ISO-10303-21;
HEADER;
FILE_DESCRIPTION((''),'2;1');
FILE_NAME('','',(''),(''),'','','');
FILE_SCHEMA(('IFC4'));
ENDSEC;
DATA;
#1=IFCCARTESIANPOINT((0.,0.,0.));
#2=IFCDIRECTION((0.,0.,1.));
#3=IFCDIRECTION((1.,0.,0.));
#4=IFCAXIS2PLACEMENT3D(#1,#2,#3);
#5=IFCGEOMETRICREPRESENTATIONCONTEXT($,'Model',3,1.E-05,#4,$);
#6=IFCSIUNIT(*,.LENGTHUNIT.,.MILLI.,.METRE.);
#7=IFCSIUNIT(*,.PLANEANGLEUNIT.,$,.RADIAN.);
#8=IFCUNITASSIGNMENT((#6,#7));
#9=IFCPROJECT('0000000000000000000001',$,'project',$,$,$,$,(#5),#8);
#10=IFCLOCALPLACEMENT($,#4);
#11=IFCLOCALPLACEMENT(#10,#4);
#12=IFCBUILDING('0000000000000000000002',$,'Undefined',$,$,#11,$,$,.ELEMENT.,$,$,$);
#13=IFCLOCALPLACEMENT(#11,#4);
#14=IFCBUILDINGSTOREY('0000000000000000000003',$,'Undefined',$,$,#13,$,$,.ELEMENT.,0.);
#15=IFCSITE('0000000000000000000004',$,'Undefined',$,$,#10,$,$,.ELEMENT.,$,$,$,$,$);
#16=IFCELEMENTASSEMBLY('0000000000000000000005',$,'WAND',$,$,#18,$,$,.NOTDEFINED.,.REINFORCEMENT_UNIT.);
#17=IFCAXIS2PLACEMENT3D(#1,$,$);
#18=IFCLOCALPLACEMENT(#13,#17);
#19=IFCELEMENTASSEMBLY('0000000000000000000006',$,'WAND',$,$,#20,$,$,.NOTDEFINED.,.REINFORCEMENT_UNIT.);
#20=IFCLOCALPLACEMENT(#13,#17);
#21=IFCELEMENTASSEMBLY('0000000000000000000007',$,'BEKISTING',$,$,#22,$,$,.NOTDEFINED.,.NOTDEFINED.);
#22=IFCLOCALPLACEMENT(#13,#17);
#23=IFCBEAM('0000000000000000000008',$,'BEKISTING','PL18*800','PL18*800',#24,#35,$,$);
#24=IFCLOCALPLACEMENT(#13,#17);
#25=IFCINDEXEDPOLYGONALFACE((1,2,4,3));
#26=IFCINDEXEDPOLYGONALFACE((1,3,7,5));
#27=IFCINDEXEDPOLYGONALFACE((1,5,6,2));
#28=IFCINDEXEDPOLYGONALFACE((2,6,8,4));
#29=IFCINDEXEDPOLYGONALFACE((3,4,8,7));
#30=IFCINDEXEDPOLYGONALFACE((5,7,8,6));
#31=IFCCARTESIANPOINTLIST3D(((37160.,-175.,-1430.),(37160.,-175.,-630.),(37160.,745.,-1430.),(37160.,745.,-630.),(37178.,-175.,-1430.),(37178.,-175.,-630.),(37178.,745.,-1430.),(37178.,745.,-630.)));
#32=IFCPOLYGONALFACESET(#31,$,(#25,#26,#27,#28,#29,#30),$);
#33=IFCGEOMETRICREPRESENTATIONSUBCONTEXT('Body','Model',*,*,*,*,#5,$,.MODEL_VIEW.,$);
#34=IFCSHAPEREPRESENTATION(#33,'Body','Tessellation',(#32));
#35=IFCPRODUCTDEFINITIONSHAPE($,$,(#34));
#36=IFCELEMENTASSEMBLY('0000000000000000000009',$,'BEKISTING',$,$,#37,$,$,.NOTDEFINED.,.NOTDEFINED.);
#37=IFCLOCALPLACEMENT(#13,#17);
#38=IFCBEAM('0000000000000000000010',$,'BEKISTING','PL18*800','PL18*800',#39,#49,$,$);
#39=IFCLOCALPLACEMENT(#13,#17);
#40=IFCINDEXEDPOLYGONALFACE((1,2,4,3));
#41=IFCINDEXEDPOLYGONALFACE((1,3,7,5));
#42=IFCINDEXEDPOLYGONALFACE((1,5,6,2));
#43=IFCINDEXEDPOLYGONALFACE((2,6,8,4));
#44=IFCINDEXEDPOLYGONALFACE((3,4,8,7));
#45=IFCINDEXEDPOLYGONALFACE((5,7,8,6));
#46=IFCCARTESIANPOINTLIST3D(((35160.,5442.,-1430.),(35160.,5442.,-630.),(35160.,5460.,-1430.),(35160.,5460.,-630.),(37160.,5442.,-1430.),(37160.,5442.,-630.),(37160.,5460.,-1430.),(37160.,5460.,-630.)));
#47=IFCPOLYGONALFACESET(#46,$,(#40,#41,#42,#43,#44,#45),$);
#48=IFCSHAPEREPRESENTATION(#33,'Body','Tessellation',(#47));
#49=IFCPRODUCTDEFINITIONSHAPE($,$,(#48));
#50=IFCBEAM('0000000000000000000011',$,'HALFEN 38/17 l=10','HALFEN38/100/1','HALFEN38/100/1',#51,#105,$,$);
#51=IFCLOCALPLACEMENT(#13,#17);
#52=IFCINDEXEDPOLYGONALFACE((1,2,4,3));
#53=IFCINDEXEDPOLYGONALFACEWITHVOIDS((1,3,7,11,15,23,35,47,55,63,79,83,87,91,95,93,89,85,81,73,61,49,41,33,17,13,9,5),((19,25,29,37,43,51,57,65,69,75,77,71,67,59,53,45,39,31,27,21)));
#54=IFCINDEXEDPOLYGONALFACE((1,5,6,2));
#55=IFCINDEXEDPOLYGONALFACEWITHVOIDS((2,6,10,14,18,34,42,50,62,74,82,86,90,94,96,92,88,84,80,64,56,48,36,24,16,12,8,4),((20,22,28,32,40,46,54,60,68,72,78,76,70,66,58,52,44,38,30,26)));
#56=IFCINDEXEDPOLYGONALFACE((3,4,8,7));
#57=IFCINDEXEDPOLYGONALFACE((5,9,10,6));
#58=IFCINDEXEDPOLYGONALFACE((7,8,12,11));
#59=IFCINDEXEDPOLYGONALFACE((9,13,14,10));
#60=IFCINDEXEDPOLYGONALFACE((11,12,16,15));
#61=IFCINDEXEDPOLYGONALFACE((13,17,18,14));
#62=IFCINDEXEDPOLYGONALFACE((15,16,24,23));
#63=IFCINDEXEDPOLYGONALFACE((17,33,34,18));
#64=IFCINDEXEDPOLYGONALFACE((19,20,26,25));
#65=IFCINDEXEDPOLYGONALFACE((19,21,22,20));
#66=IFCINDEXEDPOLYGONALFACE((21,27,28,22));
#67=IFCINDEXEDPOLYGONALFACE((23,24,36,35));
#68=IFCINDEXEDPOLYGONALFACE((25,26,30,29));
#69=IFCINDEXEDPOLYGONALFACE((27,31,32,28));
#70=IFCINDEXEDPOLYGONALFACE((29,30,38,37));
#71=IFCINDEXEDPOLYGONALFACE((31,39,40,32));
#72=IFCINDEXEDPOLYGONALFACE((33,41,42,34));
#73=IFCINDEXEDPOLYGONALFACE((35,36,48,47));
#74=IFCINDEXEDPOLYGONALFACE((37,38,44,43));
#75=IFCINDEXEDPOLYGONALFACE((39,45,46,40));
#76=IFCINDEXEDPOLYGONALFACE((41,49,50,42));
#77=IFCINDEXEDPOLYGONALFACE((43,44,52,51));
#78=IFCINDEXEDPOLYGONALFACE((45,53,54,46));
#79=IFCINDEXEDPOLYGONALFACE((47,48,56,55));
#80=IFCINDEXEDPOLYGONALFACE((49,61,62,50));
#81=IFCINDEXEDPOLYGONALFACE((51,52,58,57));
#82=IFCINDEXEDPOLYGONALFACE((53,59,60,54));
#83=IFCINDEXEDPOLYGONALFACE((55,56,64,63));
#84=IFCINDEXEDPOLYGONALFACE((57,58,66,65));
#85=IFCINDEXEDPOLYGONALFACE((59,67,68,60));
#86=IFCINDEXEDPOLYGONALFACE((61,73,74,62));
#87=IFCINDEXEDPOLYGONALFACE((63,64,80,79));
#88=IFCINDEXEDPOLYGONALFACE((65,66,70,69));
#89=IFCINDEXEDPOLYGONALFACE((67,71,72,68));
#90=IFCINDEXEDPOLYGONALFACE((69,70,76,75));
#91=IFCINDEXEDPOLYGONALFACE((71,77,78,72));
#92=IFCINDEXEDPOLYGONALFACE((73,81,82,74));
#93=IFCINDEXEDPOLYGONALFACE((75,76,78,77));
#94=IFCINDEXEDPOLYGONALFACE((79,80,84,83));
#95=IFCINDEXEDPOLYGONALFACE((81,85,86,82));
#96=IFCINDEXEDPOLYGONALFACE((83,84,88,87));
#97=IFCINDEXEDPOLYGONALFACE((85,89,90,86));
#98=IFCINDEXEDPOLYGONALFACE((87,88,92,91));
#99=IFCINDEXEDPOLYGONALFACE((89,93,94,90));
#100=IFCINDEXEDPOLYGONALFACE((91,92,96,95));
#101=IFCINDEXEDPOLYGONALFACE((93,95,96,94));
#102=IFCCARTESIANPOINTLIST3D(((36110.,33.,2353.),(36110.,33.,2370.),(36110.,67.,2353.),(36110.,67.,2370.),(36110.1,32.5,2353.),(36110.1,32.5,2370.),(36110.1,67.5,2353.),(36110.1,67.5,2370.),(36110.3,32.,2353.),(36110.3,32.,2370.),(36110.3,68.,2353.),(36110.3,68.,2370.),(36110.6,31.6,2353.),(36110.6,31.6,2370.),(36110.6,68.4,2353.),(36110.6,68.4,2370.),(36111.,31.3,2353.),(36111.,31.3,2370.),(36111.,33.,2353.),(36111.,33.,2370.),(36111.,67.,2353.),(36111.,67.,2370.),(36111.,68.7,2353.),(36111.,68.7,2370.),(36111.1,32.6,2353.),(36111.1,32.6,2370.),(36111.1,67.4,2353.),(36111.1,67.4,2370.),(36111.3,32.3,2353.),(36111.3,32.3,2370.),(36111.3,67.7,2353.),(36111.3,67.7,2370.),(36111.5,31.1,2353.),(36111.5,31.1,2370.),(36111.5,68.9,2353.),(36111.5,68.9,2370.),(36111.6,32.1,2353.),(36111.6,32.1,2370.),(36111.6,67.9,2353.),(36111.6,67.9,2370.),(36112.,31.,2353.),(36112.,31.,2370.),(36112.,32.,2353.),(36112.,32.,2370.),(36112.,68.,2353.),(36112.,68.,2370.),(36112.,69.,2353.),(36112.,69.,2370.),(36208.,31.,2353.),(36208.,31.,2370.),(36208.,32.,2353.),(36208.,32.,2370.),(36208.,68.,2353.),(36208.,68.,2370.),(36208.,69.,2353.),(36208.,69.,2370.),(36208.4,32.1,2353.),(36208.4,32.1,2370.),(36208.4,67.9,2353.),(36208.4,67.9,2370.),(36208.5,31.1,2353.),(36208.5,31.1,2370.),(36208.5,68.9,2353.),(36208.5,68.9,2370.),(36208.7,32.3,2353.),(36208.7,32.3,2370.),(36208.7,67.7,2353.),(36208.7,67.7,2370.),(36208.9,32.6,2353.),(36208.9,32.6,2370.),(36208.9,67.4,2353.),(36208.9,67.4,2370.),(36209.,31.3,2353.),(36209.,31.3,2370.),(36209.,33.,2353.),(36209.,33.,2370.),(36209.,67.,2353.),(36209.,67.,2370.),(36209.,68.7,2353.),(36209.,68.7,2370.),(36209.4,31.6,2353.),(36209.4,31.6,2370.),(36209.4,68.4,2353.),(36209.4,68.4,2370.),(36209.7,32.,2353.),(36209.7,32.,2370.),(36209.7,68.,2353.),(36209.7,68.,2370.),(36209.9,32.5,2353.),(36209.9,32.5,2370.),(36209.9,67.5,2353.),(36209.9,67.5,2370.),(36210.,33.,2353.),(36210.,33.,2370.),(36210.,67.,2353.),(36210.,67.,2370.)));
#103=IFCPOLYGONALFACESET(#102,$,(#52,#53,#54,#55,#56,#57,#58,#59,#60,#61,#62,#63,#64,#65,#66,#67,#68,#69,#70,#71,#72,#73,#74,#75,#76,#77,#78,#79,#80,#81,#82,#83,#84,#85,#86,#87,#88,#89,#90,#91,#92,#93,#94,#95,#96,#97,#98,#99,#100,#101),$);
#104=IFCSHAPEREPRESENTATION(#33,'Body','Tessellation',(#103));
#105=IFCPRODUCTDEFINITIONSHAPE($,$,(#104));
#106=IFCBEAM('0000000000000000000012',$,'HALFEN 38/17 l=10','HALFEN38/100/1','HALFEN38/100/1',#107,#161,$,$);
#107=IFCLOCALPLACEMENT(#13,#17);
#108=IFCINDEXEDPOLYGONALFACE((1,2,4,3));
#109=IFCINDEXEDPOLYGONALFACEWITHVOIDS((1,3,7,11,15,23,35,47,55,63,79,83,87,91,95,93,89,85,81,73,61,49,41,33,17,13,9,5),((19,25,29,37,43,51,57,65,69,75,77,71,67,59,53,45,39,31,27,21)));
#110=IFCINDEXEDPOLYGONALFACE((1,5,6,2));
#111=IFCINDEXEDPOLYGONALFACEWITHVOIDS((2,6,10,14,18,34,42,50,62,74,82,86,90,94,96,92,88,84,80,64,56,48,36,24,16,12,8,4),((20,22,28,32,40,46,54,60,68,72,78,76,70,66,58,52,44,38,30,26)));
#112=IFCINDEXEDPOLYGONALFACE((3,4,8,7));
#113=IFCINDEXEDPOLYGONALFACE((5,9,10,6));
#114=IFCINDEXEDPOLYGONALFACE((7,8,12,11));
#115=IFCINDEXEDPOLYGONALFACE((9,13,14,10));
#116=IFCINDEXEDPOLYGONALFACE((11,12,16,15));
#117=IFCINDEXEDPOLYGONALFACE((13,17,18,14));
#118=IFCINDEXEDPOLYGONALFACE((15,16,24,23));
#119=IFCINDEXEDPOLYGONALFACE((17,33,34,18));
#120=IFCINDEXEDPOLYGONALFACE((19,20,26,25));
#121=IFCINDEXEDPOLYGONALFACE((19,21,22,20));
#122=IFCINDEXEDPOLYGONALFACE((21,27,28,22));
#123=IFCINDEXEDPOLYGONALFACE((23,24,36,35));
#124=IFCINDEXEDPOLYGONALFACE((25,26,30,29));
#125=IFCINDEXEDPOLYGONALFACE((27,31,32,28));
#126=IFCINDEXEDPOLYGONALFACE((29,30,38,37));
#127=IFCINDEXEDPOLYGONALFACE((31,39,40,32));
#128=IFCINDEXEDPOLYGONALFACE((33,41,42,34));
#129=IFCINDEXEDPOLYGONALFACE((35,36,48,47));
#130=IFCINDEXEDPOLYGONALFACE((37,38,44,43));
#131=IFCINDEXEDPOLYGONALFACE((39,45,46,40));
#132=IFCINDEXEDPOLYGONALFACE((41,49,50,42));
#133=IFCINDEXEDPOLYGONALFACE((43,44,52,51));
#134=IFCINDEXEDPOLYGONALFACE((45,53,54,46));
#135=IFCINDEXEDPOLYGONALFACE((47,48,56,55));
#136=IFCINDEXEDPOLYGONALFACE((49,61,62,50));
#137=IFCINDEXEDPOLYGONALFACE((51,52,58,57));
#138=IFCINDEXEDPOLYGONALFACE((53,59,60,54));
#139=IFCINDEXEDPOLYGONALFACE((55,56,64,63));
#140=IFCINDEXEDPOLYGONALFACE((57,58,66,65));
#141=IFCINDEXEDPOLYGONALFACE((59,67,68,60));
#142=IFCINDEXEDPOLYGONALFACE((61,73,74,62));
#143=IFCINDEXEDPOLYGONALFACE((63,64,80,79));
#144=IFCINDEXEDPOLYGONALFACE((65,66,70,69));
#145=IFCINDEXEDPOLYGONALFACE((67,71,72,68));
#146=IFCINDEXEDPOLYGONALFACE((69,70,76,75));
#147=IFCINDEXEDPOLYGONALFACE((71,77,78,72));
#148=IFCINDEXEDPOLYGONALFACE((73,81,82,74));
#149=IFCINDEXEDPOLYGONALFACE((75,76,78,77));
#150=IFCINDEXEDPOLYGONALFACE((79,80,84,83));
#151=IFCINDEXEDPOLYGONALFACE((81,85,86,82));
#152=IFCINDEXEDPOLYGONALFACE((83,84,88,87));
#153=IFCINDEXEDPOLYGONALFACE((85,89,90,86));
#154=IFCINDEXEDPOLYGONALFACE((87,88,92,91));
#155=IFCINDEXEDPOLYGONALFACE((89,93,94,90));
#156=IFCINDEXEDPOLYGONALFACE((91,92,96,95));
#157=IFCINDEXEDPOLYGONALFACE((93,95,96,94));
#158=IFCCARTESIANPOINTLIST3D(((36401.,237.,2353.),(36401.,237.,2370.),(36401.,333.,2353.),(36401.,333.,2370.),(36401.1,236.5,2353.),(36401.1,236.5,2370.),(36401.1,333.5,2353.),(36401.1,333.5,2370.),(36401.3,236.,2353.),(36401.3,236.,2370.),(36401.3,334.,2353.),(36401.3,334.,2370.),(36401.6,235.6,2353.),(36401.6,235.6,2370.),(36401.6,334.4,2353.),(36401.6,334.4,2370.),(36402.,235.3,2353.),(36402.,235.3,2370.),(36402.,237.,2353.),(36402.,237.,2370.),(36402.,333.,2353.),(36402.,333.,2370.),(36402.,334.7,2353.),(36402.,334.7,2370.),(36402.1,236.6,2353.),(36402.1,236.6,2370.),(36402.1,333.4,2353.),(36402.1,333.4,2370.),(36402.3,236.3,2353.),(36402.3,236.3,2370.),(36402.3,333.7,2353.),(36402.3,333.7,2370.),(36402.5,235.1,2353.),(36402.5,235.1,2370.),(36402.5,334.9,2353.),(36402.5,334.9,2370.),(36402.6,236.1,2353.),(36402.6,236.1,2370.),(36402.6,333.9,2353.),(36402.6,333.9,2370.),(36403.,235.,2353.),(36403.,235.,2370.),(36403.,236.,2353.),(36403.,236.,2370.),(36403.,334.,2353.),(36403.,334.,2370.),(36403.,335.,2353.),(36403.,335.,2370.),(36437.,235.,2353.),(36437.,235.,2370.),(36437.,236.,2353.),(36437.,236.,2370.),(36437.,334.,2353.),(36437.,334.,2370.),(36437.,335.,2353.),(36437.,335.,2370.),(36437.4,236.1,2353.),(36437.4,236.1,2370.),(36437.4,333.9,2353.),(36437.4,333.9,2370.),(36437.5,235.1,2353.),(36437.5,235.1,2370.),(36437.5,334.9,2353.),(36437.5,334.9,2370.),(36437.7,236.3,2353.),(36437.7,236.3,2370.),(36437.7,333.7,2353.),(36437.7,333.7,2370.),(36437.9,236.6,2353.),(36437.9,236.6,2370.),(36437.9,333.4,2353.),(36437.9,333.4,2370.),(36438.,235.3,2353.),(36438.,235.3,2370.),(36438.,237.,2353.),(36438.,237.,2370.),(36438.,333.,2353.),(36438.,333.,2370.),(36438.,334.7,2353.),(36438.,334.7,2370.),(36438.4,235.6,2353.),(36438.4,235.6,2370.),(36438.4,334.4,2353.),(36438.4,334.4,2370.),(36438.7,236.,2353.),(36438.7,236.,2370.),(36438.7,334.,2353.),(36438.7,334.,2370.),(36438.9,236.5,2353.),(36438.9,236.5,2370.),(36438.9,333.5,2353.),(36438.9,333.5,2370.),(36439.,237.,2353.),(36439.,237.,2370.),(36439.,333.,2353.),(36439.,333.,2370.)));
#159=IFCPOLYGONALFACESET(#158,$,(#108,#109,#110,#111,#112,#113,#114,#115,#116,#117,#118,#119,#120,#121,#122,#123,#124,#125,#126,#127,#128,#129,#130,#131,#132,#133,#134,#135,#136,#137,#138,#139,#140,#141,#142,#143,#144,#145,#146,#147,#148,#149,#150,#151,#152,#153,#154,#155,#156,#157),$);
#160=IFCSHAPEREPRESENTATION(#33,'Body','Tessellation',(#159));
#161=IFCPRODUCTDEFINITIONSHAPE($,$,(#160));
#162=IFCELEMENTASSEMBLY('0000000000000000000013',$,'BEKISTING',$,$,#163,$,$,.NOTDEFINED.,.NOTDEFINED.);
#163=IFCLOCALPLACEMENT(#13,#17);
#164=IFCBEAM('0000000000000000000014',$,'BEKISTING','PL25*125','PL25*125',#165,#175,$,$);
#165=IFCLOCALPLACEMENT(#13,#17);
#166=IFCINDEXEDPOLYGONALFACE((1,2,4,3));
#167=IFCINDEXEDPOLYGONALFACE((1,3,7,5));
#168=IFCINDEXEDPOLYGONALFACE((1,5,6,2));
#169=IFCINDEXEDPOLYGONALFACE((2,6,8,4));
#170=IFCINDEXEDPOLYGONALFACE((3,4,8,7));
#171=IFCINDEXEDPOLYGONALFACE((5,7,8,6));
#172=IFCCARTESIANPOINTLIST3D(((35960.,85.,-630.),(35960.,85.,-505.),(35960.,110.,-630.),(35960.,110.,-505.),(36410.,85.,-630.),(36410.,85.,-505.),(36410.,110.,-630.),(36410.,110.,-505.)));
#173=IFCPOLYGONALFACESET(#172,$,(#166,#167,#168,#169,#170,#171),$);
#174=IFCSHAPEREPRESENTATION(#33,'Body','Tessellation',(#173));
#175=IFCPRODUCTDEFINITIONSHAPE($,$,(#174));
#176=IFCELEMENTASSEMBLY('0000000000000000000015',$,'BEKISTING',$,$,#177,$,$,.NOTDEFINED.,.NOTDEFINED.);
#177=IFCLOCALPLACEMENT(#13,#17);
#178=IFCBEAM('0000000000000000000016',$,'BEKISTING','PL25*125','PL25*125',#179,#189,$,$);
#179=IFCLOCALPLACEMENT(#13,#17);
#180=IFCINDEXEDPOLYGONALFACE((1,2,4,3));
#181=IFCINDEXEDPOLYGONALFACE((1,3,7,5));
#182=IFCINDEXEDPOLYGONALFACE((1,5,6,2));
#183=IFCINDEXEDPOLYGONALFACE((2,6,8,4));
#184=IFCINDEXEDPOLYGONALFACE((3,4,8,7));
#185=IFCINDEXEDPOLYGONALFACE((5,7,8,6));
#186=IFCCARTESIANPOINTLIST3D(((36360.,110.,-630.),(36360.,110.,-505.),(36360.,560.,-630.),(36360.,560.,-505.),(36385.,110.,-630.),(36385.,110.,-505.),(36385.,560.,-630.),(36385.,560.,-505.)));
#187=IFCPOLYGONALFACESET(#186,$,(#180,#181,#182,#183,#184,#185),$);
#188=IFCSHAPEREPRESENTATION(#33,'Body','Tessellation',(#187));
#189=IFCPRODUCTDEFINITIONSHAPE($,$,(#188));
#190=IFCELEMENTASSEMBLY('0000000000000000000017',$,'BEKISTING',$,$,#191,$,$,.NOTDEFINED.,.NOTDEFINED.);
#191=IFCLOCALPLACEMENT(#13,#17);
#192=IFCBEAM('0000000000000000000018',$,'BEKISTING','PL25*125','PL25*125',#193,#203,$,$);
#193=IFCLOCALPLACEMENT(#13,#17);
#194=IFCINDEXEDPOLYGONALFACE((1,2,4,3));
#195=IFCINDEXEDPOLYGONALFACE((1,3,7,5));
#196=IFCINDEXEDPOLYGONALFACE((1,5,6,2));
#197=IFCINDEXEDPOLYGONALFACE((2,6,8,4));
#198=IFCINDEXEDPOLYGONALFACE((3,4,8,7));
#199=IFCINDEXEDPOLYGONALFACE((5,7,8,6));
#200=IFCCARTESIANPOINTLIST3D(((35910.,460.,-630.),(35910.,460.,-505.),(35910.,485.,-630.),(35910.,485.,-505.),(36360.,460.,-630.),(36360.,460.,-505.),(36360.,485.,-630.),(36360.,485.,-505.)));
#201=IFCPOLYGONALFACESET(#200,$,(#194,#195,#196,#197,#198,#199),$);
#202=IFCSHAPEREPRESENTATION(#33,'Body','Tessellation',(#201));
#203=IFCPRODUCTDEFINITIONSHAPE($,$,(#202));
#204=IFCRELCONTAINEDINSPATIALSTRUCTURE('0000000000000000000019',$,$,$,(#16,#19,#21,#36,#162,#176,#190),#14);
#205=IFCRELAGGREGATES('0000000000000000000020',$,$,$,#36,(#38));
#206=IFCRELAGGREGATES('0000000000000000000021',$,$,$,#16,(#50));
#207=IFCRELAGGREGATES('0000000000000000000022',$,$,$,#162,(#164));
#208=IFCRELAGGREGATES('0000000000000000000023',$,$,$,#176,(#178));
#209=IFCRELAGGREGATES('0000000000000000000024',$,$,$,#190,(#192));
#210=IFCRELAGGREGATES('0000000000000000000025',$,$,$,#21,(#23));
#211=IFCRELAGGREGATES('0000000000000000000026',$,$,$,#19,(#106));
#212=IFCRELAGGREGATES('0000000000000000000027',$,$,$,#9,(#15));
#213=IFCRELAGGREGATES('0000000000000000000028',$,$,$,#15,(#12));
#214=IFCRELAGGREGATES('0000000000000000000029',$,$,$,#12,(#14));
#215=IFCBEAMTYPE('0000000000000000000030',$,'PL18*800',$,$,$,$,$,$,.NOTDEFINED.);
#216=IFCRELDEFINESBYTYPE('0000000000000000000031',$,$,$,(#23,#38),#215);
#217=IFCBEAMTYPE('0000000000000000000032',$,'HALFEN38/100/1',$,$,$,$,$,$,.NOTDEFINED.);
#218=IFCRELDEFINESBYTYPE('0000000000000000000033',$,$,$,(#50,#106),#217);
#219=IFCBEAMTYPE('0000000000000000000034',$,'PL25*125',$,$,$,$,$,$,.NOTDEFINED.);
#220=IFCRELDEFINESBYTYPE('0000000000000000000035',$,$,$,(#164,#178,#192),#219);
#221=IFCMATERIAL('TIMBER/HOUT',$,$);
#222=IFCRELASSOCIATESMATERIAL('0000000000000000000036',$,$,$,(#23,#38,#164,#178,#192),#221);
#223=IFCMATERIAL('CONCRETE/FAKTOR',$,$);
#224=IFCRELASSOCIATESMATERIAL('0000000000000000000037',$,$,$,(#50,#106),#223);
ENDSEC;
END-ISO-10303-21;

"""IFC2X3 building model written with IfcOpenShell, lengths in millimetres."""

from ifc_helpers import new_model, si_unit, frame, frame_2d, origin_with_axes, place, context, subcontext, project, spatial, rectangle, hollow_rectangle, extrude, material, type_object, element, aggregate, save


model = new_model("IFC2X3")

# Units and contexts
model_context = context("Model", 3, precision=1e-05, world=origin_with_axes())
body_context = subcontext(model_context, "Body", "Model", "MODEL_VIEW")
ifc_project = project(units=[si_unit("LENGTHUNIT", "METRE", prefix="MILLI"), si_unit("PLANEANGLEUNIT", "RADIAN")], contexts=[model_context])

# Site, building, storey
site_placement = place(None, origin_with_axes())
site = spatial("IfcSite", under=ifc_project, at=site_placement, Name="Undefined", CompositionType="ELEMENT")
building_placement = place(site_placement, origin_with_axes())
building = spatial("IfcBuilding", under=site, at=building_placement, Name="Undefined", CompositionType="ELEMENT")
storey_placement = place(building_placement, origin_with_axes())
storey = spatial("IfcBuildingStorey", under=building, at=storey_placement, Name="Undefined", CompositionType="ELEMENT", Elevation=0.0)

# Element assemblies
assembly_1_placement = place(storey_placement, origin_with_axes())
assembly_1 = element("IfcElementAssembly", 1, at=assembly_1_placement, inside=storey, Name="WAND", AssemblyPlace="NOTDEFINED", PredefinedType="REINFORCEMENT_UNIT")
ifc_material_1 = material(Name="CONCRETE/FAKTOR")
assembly_2_placement = place(storey_placement, origin_with_axes())
assembly_2 = element("IfcElementAssembly", 2, at=assembly_2_placement, inside=storey, Name="WAND", AssemblyPlace="NOTDEFINED", PredefinedType="REINFORCEMENT_UNIT")

# Element assemblies, beams
ifc_material_2 = material(Name="TIMBER/HOUT")
beam_type_1 = type_object("IfcBeamType", Name="PL18*800", PredefinedType="NOTDEFINED")
assembly_3_placement = place(storey_placement, origin_with_axes())
assembly_3 = element("IfcElementAssembly", 3, at=assembly_3_placement, inside=storey, Name="BEKISTING", AssemblyPlace="NOTDEFINED", PredefinedType="NOTDEFINED")
beam_1_placement = place(assembly_3_placement, frame((37169.0, 745.0, -1030.0), z_axis=(0.0, 0.0, 1.0), x_axis=(0.0, -1.0, 0.0)))
beam_1 = element("IfcBeam", 4, at=beam_1_placement, type_object=beam_type_1, material=ifc_material_2, Name="BEKISTING", Description="PL18*800", ObjectType="PL18*800", context=body_context, shape_type="SweptSolid", body=[
    extrude(rectangle(XDim=18.0, YDim=800.0, at=frame_2d((0.0, 0.0), x_axis=(1.0, 0.0))), frame((920.0, 0.0, 0.0), z_axis=(-1.0, 0.0, 0.0), x_axis=(0.0, -1.0, 0.0)), (0.0, 0.0, 1.0), 920.0),
])
assembly_4_placement = place(storey_placement, origin_with_axes())
assembly_4 = element("IfcElementAssembly", 5, at=assembly_4_placement, inside=storey, Name="BEKISTING", AssemblyPlace="NOTDEFINED", PredefinedType="NOTDEFINED")
beam_2_placement = place(assembly_4_placement, frame((37160.0, 5451.0, -1030.0), z_axis=(0.0, 0.0, -1.0), x_axis=(-1.0, 0.0, 0.0)))
beam_2 = element("IfcBeam", 6, at=beam_2_placement, type_object=beam_type_1, material=ifc_material_2, Name="BEKISTING", Description="PL18*800", ObjectType="PL18*800", context=body_context, shape_type="SweptSolid", body=[
    extrude(rectangle(XDim=18.0, YDim=800.0, at=frame_2d((0.0, 0.0), x_axis=(1.0, 0.0))), frame((2000.0, 0.0, 0.0), z_axis=(-1.0, 0.0, 0.0), x_axis=(0.0, -1.0, 0.0)), (0.0, 0.0, 1.0), 2000.0),
])
aggregate(assembly_4, [beam_2])

# Beams
beam_type_2 = type_object("IfcBeamType", Name="HALFEN38/100/1", PredefinedType="NOTDEFINED")
beam_3_placement = place(assembly_1_placement, frame((36160.0, 50.0, 2370.0), z_axis=(0.0, -1.0, 0.0), x_axis=(0.0, 0.0, -1.0)))
beam_3 = element("IfcBeam", 7, at=beam_3_placement, type_object=beam_type_2, material=ifc_material_1, Name="HALFEN 38/17 l=10", Description="HALFEN38/100/1", ObjectType="HALFEN38/100/1", context=body_context, shape_type="SweptSolid", body=[
    extrude(hollow_rectangle(XDim=100.0, YDim=38.0, WallThickness=1.0, InnerFilletRadius=1.0, OuterFilletRadius=2.0, at=frame_2d((0.0, 0.0), x_axis=(1.0, 0.0))), frame((17.0, 0.0, 0.0), z_axis=(-1.0, 0.0, 0.0), x_axis=(0.0, -1.0, 0.0)), (0.0, 0.0, 1.0), 17.0),
])
aggregate(assembly_1, [beam_3])
beam_4_placement = place(assembly_2_placement, frame((36420.0, 285.0, 2370.0), z_axis=(1.0, 0.0, 0.0), x_axis=(0.0, 0.0, -1.0)))
beam_4 = element("IfcBeam", 8, at=beam_4_placement, type_object=beam_type_2, material=ifc_material_1, Name="HALFEN 38/17 l=10", Description="HALFEN38/100/1", ObjectType="HALFEN38/100/1", context=body_context, shape_type="SweptSolid", body=[
    extrude(hollow_rectangle(XDim=100.0, YDim=38.0, WallThickness=1.0, InnerFilletRadius=1.0, OuterFilletRadius=2.0, at=frame_2d((0.0, 0.0), x_axis=(1.0, 0.0))), frame((17.0, 0.0, 0.0), z_axis=(-1.0, 0.0, 0.0), x_axis=(0.0, -1.0, 0.0)), (0.0, 0.0, 1.0), 17.0),
])

# Element assemblies, beams
assembly_5_placement = place(storey_placement, origin_with_axes())
assembly_5 = element("IfcElementAssembly", 9, at=assembly_5_placement, inside=storey, Name="BEKISTING", AssemblyPlace="NOTDEFINED", PredefinedType="NOTDEFINED")
beam_type_3 = type_object("IfcBeamType", Name="PL25*125", PredefinedType="NOTDEFINED")
beam_5_placement = place(assembly_5_placement, frame((36410.0, 97.5, -567.5), z_axis=(0.0, 0.0, -1.0), x_axis=(-1.0, 0.0, 0.0)))
beam_5 = element("IfcBeam", 10, at=beam_5_placement, type_object=beam_type_3, material=ifc_material_2, Name="BEKISTING", Description="PL25*125", ObjectType="PL25*125", context=body_context, shape_type="SweptSolid", body=[
    extrude(rectangle(XDim=25.0, YDim=125.0, at=frame_2d((0.0, 0.0), x_axis=(1.0, 0.0))), frame((450.0, 0.0, 0.0), z_axis=(-1.0, 0.0, 0.0), x_axis=(0.0, -1.0, 0.0)), (0.0, 0.0, 1.0), 450.0),
])
aggregate(assembly_5, [beam_5])
assembly_6_placement = place(storey_placement, origin_with_axes())
assembly_6 = element("IfcElementAssembly", 11, at=assembly_6_placement, inside=storey, Name="BEKISTING", AssemblyPlace="NOTDEFINED", PredefinedType="NOTDEFINED")
beam_6_placement = place(assembly_6_placement, frame((36372.5, 110.0, -567.5), z_axis=(0.0, 0.0, -1.0), x_axis=(0.0, 1.0, 0.0)))
beam_6 = element("IfcBeam", 12, at=beam_6_placement, type_object=beam_type_3, material=ifc_material_2, Name="BEKISTING", Description="PL25*125", ObjectType="PL25*125", context=body_context, shape_type="SweptSolid", body=[
    extrude(rectangle(XDim=25.0, YDim=125.0, at=frame_2d((0.0, 0.0), x_axis=(1.0, 0.0))), frame((450.0, 0.0, 0.0), z_axis=(-1.0, 0.0, 0.0), x_axis=(0.0, -1.0, 0.0)), (0.0, 0.0, 1.0), 450.0),
])
aggregate(assembly_6, [beam_6])
assembly_7_placement = place(storey_placement, origin_with_axes())
assembly_7 = element("IfcElementAssembly", 13, at=assembly_7_placement, inside=storey, Name="BEKISTING", AssemblyPlace="NOTDEFINED", PredefinedType="NOTDEFINED")
beam_7_placement = place(assembly_7_placement, frame((36360.0, 472.5, -567.5), z_axis=(0.0, 0.0, -1.0), x_axis=(-1.0, 0.0, 0.0)))
beam_7 = element("IfcBeam", 14, at=beam_7_placement, type_object=beam_type_3, material=ifc_material_2, Name="BEKISTING", Description="PL25*125", ObjectType="PL25*125", context=body_context, shape_type="SweptSolid", body=[
    extrude(rectangle(XDim=25.0, YDim=125.0, at=frame_2d((0.0, 0.0), x_axis=(1.0, 0.0))), frame((450.0, 0.0, 0.0), z_axis=(-1.0, 0.0, 0.0), x_axis=(0.0, -1.0, 0.0)), (0.0, 0.0, 1.0), 450.0),
])
aggregate(assembly_7, [beam_7])

aggregate(assembly_3, [beam_1])

aggregate(assembly_2, [beam_4])

save(model, "model.ifc")
